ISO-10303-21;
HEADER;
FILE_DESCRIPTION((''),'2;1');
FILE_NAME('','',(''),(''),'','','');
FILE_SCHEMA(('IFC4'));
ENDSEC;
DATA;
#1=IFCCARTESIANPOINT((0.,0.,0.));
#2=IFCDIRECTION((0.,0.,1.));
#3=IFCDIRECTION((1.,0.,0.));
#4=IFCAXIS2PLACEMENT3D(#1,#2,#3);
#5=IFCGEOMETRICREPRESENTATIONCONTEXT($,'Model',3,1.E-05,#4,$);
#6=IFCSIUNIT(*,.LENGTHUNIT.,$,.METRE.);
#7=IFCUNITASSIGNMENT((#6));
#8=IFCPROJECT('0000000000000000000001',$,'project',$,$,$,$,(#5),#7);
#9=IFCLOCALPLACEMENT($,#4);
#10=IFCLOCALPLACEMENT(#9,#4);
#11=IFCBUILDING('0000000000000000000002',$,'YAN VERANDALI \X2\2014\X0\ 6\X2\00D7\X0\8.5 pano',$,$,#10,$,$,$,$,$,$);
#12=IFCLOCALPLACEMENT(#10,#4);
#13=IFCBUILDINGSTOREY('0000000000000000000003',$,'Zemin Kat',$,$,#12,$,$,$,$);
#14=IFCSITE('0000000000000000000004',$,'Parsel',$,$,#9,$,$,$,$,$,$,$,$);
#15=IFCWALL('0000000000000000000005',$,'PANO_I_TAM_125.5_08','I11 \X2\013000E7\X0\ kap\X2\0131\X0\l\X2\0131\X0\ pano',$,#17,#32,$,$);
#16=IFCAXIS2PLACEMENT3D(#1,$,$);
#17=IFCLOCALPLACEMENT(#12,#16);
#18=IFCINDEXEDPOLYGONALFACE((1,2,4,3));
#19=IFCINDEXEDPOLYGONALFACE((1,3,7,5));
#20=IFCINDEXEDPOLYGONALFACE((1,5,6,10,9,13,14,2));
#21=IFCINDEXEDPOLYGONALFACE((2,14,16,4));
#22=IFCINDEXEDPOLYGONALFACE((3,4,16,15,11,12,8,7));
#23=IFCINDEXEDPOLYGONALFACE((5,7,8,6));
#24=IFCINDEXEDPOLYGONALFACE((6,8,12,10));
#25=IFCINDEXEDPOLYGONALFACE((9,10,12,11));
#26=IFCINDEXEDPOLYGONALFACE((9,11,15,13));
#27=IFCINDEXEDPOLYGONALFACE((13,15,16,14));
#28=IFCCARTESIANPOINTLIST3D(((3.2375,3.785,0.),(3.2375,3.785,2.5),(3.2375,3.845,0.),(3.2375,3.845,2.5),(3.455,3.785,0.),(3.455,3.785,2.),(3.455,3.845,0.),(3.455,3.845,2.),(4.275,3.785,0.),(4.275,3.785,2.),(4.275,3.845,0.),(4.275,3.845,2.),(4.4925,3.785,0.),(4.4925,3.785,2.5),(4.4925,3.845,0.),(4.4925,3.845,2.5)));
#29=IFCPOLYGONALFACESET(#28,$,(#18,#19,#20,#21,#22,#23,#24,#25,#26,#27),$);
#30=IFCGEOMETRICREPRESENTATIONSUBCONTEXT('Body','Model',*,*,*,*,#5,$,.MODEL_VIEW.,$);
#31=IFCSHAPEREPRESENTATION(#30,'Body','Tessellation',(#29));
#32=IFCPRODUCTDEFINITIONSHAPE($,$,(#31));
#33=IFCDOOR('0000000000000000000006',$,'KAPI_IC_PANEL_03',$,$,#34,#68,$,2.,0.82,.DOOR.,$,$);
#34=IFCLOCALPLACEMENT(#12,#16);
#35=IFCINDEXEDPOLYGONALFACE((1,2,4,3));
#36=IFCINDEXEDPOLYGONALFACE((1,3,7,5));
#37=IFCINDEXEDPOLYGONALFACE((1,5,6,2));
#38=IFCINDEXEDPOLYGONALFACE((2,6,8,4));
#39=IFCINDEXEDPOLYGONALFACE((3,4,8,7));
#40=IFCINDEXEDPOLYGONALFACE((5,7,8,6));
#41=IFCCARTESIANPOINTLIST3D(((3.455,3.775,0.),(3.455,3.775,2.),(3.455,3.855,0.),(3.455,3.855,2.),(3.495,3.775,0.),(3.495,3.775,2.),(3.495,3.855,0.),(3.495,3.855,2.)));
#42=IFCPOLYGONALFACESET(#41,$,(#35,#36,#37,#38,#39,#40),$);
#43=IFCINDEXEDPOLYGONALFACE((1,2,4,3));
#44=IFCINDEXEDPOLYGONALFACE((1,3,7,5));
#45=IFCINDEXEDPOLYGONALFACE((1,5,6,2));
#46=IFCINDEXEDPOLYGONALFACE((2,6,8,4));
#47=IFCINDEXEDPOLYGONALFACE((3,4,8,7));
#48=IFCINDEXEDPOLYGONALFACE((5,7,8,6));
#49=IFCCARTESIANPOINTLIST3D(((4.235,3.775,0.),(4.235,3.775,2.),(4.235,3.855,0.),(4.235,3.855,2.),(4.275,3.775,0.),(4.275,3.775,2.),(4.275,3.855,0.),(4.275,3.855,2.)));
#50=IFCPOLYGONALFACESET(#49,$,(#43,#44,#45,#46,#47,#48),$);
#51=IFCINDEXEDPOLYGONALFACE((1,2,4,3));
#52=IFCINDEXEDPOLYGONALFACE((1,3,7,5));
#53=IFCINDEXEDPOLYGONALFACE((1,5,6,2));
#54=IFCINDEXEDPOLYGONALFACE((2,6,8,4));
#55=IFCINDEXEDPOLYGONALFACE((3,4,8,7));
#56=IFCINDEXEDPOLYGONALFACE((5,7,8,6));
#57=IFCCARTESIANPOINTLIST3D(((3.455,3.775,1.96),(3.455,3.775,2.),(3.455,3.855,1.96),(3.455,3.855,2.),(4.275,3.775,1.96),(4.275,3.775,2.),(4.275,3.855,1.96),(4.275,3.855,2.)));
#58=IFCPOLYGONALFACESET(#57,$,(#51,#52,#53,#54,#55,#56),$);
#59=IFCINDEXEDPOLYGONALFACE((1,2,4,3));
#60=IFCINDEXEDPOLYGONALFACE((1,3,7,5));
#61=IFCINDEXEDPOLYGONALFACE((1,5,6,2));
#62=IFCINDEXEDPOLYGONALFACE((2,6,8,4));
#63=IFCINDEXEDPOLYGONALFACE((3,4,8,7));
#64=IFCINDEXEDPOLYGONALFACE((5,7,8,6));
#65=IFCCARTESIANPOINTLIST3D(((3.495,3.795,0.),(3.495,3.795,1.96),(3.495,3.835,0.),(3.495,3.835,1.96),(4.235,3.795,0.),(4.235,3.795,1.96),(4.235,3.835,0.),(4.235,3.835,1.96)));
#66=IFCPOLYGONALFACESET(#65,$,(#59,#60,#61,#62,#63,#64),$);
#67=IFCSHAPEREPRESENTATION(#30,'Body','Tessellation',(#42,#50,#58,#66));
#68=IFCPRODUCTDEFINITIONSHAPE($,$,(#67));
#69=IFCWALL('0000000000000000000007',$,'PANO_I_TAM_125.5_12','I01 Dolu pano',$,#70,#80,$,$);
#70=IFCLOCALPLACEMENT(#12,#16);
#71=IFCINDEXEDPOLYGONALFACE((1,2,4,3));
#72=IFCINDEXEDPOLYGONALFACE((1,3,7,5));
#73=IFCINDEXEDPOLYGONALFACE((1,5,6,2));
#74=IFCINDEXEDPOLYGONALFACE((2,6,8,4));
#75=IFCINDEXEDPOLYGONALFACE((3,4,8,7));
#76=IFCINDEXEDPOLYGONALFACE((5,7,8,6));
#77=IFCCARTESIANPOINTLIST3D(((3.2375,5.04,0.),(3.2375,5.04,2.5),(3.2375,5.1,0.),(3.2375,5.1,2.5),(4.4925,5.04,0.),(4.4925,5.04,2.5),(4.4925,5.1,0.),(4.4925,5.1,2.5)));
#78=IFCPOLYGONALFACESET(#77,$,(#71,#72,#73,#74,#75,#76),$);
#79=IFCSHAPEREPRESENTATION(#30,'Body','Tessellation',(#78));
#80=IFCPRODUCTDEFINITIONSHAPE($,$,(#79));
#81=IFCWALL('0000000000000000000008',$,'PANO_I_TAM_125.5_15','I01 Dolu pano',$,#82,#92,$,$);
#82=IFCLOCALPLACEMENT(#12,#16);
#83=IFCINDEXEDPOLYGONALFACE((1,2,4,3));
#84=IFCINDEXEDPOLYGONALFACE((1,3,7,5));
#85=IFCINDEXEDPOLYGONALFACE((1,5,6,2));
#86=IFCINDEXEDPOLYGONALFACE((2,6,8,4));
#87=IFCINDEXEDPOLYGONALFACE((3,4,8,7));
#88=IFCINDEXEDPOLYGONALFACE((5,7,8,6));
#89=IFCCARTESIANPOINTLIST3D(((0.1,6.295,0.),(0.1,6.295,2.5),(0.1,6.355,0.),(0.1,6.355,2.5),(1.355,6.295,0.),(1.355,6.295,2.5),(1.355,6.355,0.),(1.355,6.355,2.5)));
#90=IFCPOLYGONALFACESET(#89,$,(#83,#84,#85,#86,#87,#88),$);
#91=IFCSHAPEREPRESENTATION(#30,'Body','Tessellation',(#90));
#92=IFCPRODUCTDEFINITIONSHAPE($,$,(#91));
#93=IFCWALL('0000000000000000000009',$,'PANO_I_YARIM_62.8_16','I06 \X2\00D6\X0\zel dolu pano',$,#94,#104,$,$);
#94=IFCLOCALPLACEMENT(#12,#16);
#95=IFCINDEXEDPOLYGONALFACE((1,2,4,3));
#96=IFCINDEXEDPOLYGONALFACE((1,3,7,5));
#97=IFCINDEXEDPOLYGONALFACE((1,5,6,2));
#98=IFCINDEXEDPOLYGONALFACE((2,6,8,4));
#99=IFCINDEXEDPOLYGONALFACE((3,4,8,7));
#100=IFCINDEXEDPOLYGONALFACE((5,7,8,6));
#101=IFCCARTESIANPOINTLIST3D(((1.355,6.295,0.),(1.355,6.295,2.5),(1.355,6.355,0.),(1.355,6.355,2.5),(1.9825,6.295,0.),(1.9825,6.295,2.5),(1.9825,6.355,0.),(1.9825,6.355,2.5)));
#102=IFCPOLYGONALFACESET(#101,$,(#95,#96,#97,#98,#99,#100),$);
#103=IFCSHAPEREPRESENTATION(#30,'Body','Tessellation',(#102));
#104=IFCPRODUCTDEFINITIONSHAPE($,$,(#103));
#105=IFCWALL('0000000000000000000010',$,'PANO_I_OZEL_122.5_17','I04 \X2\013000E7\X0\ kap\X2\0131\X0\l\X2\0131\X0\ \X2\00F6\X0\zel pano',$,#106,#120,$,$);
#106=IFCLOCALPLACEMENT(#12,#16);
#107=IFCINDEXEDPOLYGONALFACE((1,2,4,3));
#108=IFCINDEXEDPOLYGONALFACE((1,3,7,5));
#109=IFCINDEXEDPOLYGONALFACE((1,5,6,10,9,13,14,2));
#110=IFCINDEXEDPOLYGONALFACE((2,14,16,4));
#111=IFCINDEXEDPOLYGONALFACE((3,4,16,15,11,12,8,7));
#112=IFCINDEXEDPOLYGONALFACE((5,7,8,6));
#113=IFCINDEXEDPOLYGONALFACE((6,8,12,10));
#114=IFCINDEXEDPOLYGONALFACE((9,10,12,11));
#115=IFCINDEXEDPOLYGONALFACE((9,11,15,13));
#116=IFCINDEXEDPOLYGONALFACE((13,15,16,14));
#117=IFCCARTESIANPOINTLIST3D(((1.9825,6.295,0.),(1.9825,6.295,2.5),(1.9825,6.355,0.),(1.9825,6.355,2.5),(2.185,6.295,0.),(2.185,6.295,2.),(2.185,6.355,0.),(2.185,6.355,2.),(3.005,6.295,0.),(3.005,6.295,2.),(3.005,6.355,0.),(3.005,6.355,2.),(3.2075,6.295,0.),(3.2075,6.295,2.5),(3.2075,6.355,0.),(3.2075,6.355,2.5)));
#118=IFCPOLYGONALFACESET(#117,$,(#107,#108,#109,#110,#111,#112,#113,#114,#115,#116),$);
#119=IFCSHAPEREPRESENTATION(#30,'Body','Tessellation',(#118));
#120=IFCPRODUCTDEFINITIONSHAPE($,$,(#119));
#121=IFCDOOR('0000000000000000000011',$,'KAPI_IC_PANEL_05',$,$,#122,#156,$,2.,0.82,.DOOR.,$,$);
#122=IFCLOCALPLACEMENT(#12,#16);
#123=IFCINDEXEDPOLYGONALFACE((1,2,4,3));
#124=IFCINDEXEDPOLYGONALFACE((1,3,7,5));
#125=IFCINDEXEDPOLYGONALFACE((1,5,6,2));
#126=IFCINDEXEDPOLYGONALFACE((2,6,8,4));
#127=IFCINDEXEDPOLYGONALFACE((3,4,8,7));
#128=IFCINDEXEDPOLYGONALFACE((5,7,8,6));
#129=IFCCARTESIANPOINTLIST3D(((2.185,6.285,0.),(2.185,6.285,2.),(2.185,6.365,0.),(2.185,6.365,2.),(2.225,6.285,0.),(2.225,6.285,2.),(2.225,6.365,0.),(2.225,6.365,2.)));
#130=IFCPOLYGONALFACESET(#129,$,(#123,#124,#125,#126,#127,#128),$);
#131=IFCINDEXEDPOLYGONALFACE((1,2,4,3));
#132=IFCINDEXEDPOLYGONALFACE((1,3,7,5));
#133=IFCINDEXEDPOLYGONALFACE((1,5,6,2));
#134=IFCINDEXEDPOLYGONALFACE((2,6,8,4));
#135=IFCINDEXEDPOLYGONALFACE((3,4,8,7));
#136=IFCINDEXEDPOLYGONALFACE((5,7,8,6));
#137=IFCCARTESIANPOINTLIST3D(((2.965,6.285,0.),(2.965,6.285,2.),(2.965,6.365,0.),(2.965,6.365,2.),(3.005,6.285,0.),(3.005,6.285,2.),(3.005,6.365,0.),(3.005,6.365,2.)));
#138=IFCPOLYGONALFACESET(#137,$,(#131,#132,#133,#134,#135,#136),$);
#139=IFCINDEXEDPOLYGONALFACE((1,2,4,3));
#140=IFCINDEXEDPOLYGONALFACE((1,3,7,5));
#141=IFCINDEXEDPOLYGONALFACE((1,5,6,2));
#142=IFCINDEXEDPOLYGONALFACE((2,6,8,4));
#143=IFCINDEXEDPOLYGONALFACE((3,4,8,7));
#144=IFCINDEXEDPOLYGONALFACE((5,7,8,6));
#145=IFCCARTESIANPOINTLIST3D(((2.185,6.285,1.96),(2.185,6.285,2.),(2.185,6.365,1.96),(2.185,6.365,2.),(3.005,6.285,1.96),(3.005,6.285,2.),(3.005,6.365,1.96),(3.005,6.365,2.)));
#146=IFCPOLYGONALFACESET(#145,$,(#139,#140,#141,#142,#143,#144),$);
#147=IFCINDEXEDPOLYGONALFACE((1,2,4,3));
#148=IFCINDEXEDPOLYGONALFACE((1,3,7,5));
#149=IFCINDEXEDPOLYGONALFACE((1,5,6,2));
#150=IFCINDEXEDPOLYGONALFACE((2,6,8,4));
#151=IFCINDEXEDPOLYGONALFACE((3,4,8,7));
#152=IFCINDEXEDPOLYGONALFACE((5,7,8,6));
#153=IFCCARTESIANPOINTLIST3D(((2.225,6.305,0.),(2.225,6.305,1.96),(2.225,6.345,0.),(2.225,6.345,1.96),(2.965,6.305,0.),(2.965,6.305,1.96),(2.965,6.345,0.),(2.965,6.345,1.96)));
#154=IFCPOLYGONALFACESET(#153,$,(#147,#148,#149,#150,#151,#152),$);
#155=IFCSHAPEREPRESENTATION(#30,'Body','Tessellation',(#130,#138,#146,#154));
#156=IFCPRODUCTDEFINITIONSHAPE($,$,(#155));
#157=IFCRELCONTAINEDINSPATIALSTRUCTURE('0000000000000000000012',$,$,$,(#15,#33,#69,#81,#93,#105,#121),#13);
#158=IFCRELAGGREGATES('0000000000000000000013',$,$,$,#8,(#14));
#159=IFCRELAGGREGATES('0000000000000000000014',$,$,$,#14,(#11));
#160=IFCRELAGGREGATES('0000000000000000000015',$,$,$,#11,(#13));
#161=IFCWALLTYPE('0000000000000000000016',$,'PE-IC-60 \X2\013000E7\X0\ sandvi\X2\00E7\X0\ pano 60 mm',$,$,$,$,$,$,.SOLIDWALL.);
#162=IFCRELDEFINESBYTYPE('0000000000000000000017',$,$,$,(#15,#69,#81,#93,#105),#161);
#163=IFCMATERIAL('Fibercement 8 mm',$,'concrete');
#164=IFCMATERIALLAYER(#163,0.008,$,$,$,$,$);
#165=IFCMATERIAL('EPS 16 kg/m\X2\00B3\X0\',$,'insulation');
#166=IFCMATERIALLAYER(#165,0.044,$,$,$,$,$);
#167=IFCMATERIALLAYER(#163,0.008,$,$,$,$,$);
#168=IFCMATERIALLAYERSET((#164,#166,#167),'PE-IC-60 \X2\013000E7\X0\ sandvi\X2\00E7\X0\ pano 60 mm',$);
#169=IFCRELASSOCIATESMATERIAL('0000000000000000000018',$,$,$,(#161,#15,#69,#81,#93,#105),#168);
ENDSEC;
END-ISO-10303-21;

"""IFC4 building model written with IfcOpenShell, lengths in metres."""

from ifc_helpers import new_model, si_unit, frame, origin_with_axes, place, context, subcontext, project, spatial, line, indexed_curve, outline, extrude, material, layer, layer_set, layer_usage, type_object, element, fill, save


model = new_model("IFC4")

# Units and contexts
model_context = context("Model", 3, precision=1e-05, world=origin_with_axes())
body_context = subcontext(model_context, "Body", "Model", "MODEL_VIEW")
ifc_project = project(units=[si_unit("LENGTHUNIT", "METRE")], contexts=[model_context])

# Site, building, storey
site_placement = place(None, origin_with_axes())
site = spatial("IfcSite", under=ifc_project, at=site_placement, Name="Parsel")
building_placement = place(site_placement, origin_with_axes())
building = spatial("IfcBuilding", under=site, at=building_placement, Name="YAN VERANDALI — 6×8.5 pano")
storey_placement = place(building_placement, origin_with_axes())
storey = spatial("IfcBuildingStorey", under=building, at=storey_placement, Name="Zemin Kat")

# Shared definitions
ifc_material_1 = material(Name="Fibercement 8 mm", Category="concrete")
ifc_material_2 = material(Name="EPS 16 kg/m³", Category="insulation")

# Shared definitions
ifc_layer_1 = layer(ifc_material_1, 0.008)
ifc_layer_2 = layer(ifc_material_2, 0.044)
ifc_layer_3 = layer(ifc_material_1, 0.008)
ifc_layer_set_1 = layer_set([ifc_layer_1, ifc_layer_2, ifc_layer_3], Name="PE-IC-60 İç sandviç pano 60 mm")
wall_type_1 = type_object("IfcWallType", Name="PE-IC-60 İç sandviç pano 60 mm", PredefinedType="SOLIDWALL", material=ifc_layer_set_1)

# Wall, opening, door
ifc_layer_usage_1 = layer_usage(ifc_layer_set_1, "AXIS2", "POSITIVE", 0.0)
wall_1_placement = place(storey_placement, frame((3.2375, 3.785, 0.0), z_axis=(0.0, 0.0, 1.0), x_axis=(1.0, 0.0, 0.0)))
wall_1 = element("IfcWall", 1, at=wall_1_placement, inside=storey, type_object=wall_type_1, material=ifc_layer_usage_1, Name="PANO_I_TAM_125.5_08", Description="I11 İç kapılı pano", context=body_context, shape_type="SweptSolid", body=[
    extrude(outline(indexed_curve([(0.0, 0.0), (1.255, 0.0), (1.255, 0.06), (0.0, 0.06)], segments=[line(1, 2, 3, 4, 1)])), origin_with_axes(), (0.0, 0.0, 1.0), 2.5),
])
opening_1_placement = place(wall_1_placement, origin_with_axes())
opening_1 = element("IfcOpeningElement", 2, at=opening_1_placement, cuts=wall_1, PredefinedType="OPENING", context=body_context, shape_type="SweptSolid", body=[
    extrude(outline(indexed_curve([(0.0, 0.0), (0.82, 0.0), (0.82, 0.1), (0.0, 0.1)], segments=[line(1, 2, 3, 4, 1)])), frame((0.2175, -0.02, 0.0), z_axis=(0.0, 0.0, 1.0), x_axis=(1.0, 0.0, 0.0)), (0.0, 0.0, 1.0), 2.0),
])
door_1_placement = place(storey_placement, frame((3.2375, 3.785, 0.0), z_axis=(0.0, 0.0, 1.0), x_axis=(1.0, 0.0, 0.0)))
door_1 = element("IfcDoor", 3, at=door_1_placement, inside=storey, Name="KAPI_IC_PANEL_03", OverallHeight=2.0, OverallWidth=0.82, PredefinedType="DOOR", context=body_context, shape_type="SweptSolid", body=[
    extrude(outline(indexed_curve([(0.0, 0.0), (0.04, 0.0), (0.04, 0.08), (0.0, 0.08)], segments=[line(1, 2, 3, 4, 1)])), frame((0.2175, -0.01, 0.0), z_axis=(0.0, 0.0, 1.0), x_axis=(1.0, 0.0, 0.0)), (0.0, 0.0, 1.0), 2.0),
    extrude(outline(indexed_curve([(0.0, 0.0), (0.04, 0.0), (0.04, 0.08), (0.0, 0.08)], segments=[line(1, 2, 3, 4, 1)])), frame((0.9975, -0.01, 0.0), z_axis=(0.0, 0.0, 1.0), x_axis=(1.0, 0.0, 0.0)), (0.0, 0.0, 1.0), 2.0),
    extrude(outline(indexed_curve([(0.0, 0.0), (0.82, 0.0), (0.82, 0.08), (0.0, 0.08)], segments=[line(1, 2, 3, 4, 1)])), frame((0.2175, -0.01, 1.96), z_axis=(0.0, 0.0, 1.0), x_axis=(1.0, 0.0, 0.0)), (0.0, 0.0, 1.0), 0.04),
    extrude(outline(indexed_curve([(0.0, 0.0), (0.74, 0.0), (0.74, 0.04), (0.0, 0.04)], segments=[line(1, 2, 3, 4, 1)])), frame((0.2575, 0.01, 0.0), z_axis=(0.0, 0.0, 1.0), x_axis=(1.0, 0.0, 0.0)), (0.0, 0.0, 1.0), 1.96),
])
fill(opening_1, door_1)

# Walls
ifc_layer_usage_2 = layer_usage(ifc_layer_set_1, "AXIS2", "POSITIVE", 0.0)
wall_2_placement = place(storey_placement, frame((3.2375, 5.04, 0.0), z_axis=(0.0, 0.0, 1.0), x_axis=(1.0, 0.0, 0.0)))
element("IfcWall", 4, at=wall_2_placement, inside=storey, type_object=wall_type_1, material=ifc_layer_usage_2, Name="PANO_I_TAM_125.5_12", Description="I01 Dolu pano", context=body_context, shape_type="SweptSolid", body=[
    extrude(outline(indexed_curve([(0.0, 0.0), (1.255, 0.0), (1.255, 0.06), (0.0, 0.06)], segments=[line(1, 2, 3, 4, 1)])), origin_with_axes(), (0.0, 0.0, 1.0), 2.5),
])
ifc_layer_usage_3 = layer_usage(ifc_layer_set_1, "AXIS2", "POSITIVE", 0.0)
wall_3_placement = place(storey_placement, frame((0.1, 6.295, 0.0), z_axis=(0.0, 0.0, 1.0), x_axis=(1.0, 0.0, 0.0)))
element("IfcWall", 5, at=wall_3_placement, inside=storey, type_object=wall_type_1, material=ifc_layer_usage_3, Name="PANO_I_TAM_125.5_15", Description="I01 Dolu pano", context=body_context, shape_type="SweptSolid", body=[
    extrude(outline(indexed_curve([(0.0, 0.0), (1.255, 0.0), (1.255, 0.06), (0.0, 0.06)], segments=[line(1, 2, 3, 4, 1)])), origin_with_axes(), (0.0, 0.0, 1.0), 2.5),
])
ifc_layer_usage_4 = layer_usage(ifc_layer_set_1, "AXIS2", "POSITIVE", 0.0)
wall_4_placement = place(storey_placement, frame((1.355, 6.295, 0.0), z_axis=(0.0, 0.0, 1.0), x_axis=(1.0, 0.0, 0.0)))
element("IfcWall", 6, at=wall_4_placement, inside=storey, type_object=wall_type_1, material=ifc_layer_usage_4, Name="PANO_I_YARIM_62.8_16", Description="I06 Özel dolu pano", context=body_context, shape_type="SweptSolid", body=[
    extrude(outline(indexed_curve([(0.0, 0.0), (0.6275, 0.0), (0.6275, 0.06), (0.0, 0.06)], segments=[line(1, 2, 3, 4, 1)])), origin_with_axes(), (0.0, 0.0, 1.0), 2.5),
])

# Wall, opening, door
ifc_layer_usage_5 = layer_usage(ifc_layer_set_1, "AXIS2", "POSITIVE", 0.0)
wall_5_placement = place(storey_placement, frame((1.9825, 6.295, 0.0), z_axis=(0.0, 0.0, 1.0), x_axis=(1.0, 0.0, 0.0)))
wall_5 = element("IfcWall", 7, at=wall_5_placement, inside=storey, type_object=wall_type_1, material=ifc_layer_usage_5, Name="PANO_I_OZEL_122.5_17", Description="I04 İç kapılı özel pano", context=body_context, shape_type="SweptSolid", body=[
    extrude(outline(indexed_curve([(0.0, 0.0), (1.225, 0.0), (1.225, 0.06), (0.0, 0.06)], segments=[line(1, 2, 3, 4, 1)])), origin_with_axes(), (0.0, 0.0, 1.0), 2.5),
])
opening_2_placement = place(wall_5_placement, origin_with_axes())
opening_2 = element("IfcOpeningElement", 8, at=opening_2_placement, cuts=wall_5, PredefinedType="OPENING", context=body_context, shape_type="SweptSolid", body=[
    extrude(outline(indexed_curve([(0.0, 0.0), (0.82, 0.0), (0.82, 0.1), (0.0, 0.1)], segments=[line(1, 2, 3, 4, 1)])), frame((0.2025, -0.02, 0.0), z_axis=(0.0, 0.0, 1.0), x_axis=(1.0, 0.0, 0.0)), (0.0, 0.0, 1.0), 2.0),
])
door_2_placement = place(storey_placement, frame((1.9825, 6.295, 0.0), z_axis=(0.0, 0.0, 1.0), x_axis=(1.0, 0.0, 0.0)))
door_2 = element("IfcDoor", 9, at=door_2_placement, inside=storey, Name="KAPI_IC_PANEL_05", OverallHeight=2.0, OverallWidth=0.82, PredefinedType="DOOR", context=body_context, shape_type="SweptSolid", body=[
    extrude(outline(indexed_curve([(0.0, 0.0), (0.04, 0.0), (0.04, 0.08), (0.0, 0.08)], segments=[line(1, 2, 3, 4, 1)])), frame((0.2025, -0.01, 0.0), z_axis=(0.0, 0.0, 1.0), x_axis=(1.0, 0.0, 0.0)), (0.0, 0.0, 1.0), 2.0),
    extrude(outline(indexed_curve([(0.0, 0.0), (0.04, 0.0), (0.04, 0.08), (0.0, 0.08)], segments=[line(1, 2, 3, 4, 1)])), frame((0.9825, -0.01, 0.0), z_axis=(0.0, 0.0, 1.0), x_axis=(1.0, 0.0, 0.0)), (0.0, 0.0, 1.0), 2.0),
    extrude(outline(indexed_curve([(0.0, 0.0), (0.82, 0.0), (0.82, 0.08), (0.0, 0.08)], segments=[line(1, 2, 3, 4, 1)])), frame((0.2025, -0.01, 1.96), z_axis=(0.0, 0.0, 1.0), x_axis=(1.0, 0.0, 0.0)), (0.0, 0.0, 1.0), 0.04),
    extrude(outline(indexed_curve([(0.0, 0.0), (0.74, 0.0), (0.74, 0.04), (0.0, 0.04)], segments=[line(1, 2, 3, 4, 1)])), frame((0.2425, 0.01, 0.0), z_axis=(0.0, 0.0, 1.0), x_axis=(1.0, 0.0, 0.0)), (0.0, 0.0, 1.0), 1.96),
])
fill(opening_2, door_2)

save(model, "model.ifc")
